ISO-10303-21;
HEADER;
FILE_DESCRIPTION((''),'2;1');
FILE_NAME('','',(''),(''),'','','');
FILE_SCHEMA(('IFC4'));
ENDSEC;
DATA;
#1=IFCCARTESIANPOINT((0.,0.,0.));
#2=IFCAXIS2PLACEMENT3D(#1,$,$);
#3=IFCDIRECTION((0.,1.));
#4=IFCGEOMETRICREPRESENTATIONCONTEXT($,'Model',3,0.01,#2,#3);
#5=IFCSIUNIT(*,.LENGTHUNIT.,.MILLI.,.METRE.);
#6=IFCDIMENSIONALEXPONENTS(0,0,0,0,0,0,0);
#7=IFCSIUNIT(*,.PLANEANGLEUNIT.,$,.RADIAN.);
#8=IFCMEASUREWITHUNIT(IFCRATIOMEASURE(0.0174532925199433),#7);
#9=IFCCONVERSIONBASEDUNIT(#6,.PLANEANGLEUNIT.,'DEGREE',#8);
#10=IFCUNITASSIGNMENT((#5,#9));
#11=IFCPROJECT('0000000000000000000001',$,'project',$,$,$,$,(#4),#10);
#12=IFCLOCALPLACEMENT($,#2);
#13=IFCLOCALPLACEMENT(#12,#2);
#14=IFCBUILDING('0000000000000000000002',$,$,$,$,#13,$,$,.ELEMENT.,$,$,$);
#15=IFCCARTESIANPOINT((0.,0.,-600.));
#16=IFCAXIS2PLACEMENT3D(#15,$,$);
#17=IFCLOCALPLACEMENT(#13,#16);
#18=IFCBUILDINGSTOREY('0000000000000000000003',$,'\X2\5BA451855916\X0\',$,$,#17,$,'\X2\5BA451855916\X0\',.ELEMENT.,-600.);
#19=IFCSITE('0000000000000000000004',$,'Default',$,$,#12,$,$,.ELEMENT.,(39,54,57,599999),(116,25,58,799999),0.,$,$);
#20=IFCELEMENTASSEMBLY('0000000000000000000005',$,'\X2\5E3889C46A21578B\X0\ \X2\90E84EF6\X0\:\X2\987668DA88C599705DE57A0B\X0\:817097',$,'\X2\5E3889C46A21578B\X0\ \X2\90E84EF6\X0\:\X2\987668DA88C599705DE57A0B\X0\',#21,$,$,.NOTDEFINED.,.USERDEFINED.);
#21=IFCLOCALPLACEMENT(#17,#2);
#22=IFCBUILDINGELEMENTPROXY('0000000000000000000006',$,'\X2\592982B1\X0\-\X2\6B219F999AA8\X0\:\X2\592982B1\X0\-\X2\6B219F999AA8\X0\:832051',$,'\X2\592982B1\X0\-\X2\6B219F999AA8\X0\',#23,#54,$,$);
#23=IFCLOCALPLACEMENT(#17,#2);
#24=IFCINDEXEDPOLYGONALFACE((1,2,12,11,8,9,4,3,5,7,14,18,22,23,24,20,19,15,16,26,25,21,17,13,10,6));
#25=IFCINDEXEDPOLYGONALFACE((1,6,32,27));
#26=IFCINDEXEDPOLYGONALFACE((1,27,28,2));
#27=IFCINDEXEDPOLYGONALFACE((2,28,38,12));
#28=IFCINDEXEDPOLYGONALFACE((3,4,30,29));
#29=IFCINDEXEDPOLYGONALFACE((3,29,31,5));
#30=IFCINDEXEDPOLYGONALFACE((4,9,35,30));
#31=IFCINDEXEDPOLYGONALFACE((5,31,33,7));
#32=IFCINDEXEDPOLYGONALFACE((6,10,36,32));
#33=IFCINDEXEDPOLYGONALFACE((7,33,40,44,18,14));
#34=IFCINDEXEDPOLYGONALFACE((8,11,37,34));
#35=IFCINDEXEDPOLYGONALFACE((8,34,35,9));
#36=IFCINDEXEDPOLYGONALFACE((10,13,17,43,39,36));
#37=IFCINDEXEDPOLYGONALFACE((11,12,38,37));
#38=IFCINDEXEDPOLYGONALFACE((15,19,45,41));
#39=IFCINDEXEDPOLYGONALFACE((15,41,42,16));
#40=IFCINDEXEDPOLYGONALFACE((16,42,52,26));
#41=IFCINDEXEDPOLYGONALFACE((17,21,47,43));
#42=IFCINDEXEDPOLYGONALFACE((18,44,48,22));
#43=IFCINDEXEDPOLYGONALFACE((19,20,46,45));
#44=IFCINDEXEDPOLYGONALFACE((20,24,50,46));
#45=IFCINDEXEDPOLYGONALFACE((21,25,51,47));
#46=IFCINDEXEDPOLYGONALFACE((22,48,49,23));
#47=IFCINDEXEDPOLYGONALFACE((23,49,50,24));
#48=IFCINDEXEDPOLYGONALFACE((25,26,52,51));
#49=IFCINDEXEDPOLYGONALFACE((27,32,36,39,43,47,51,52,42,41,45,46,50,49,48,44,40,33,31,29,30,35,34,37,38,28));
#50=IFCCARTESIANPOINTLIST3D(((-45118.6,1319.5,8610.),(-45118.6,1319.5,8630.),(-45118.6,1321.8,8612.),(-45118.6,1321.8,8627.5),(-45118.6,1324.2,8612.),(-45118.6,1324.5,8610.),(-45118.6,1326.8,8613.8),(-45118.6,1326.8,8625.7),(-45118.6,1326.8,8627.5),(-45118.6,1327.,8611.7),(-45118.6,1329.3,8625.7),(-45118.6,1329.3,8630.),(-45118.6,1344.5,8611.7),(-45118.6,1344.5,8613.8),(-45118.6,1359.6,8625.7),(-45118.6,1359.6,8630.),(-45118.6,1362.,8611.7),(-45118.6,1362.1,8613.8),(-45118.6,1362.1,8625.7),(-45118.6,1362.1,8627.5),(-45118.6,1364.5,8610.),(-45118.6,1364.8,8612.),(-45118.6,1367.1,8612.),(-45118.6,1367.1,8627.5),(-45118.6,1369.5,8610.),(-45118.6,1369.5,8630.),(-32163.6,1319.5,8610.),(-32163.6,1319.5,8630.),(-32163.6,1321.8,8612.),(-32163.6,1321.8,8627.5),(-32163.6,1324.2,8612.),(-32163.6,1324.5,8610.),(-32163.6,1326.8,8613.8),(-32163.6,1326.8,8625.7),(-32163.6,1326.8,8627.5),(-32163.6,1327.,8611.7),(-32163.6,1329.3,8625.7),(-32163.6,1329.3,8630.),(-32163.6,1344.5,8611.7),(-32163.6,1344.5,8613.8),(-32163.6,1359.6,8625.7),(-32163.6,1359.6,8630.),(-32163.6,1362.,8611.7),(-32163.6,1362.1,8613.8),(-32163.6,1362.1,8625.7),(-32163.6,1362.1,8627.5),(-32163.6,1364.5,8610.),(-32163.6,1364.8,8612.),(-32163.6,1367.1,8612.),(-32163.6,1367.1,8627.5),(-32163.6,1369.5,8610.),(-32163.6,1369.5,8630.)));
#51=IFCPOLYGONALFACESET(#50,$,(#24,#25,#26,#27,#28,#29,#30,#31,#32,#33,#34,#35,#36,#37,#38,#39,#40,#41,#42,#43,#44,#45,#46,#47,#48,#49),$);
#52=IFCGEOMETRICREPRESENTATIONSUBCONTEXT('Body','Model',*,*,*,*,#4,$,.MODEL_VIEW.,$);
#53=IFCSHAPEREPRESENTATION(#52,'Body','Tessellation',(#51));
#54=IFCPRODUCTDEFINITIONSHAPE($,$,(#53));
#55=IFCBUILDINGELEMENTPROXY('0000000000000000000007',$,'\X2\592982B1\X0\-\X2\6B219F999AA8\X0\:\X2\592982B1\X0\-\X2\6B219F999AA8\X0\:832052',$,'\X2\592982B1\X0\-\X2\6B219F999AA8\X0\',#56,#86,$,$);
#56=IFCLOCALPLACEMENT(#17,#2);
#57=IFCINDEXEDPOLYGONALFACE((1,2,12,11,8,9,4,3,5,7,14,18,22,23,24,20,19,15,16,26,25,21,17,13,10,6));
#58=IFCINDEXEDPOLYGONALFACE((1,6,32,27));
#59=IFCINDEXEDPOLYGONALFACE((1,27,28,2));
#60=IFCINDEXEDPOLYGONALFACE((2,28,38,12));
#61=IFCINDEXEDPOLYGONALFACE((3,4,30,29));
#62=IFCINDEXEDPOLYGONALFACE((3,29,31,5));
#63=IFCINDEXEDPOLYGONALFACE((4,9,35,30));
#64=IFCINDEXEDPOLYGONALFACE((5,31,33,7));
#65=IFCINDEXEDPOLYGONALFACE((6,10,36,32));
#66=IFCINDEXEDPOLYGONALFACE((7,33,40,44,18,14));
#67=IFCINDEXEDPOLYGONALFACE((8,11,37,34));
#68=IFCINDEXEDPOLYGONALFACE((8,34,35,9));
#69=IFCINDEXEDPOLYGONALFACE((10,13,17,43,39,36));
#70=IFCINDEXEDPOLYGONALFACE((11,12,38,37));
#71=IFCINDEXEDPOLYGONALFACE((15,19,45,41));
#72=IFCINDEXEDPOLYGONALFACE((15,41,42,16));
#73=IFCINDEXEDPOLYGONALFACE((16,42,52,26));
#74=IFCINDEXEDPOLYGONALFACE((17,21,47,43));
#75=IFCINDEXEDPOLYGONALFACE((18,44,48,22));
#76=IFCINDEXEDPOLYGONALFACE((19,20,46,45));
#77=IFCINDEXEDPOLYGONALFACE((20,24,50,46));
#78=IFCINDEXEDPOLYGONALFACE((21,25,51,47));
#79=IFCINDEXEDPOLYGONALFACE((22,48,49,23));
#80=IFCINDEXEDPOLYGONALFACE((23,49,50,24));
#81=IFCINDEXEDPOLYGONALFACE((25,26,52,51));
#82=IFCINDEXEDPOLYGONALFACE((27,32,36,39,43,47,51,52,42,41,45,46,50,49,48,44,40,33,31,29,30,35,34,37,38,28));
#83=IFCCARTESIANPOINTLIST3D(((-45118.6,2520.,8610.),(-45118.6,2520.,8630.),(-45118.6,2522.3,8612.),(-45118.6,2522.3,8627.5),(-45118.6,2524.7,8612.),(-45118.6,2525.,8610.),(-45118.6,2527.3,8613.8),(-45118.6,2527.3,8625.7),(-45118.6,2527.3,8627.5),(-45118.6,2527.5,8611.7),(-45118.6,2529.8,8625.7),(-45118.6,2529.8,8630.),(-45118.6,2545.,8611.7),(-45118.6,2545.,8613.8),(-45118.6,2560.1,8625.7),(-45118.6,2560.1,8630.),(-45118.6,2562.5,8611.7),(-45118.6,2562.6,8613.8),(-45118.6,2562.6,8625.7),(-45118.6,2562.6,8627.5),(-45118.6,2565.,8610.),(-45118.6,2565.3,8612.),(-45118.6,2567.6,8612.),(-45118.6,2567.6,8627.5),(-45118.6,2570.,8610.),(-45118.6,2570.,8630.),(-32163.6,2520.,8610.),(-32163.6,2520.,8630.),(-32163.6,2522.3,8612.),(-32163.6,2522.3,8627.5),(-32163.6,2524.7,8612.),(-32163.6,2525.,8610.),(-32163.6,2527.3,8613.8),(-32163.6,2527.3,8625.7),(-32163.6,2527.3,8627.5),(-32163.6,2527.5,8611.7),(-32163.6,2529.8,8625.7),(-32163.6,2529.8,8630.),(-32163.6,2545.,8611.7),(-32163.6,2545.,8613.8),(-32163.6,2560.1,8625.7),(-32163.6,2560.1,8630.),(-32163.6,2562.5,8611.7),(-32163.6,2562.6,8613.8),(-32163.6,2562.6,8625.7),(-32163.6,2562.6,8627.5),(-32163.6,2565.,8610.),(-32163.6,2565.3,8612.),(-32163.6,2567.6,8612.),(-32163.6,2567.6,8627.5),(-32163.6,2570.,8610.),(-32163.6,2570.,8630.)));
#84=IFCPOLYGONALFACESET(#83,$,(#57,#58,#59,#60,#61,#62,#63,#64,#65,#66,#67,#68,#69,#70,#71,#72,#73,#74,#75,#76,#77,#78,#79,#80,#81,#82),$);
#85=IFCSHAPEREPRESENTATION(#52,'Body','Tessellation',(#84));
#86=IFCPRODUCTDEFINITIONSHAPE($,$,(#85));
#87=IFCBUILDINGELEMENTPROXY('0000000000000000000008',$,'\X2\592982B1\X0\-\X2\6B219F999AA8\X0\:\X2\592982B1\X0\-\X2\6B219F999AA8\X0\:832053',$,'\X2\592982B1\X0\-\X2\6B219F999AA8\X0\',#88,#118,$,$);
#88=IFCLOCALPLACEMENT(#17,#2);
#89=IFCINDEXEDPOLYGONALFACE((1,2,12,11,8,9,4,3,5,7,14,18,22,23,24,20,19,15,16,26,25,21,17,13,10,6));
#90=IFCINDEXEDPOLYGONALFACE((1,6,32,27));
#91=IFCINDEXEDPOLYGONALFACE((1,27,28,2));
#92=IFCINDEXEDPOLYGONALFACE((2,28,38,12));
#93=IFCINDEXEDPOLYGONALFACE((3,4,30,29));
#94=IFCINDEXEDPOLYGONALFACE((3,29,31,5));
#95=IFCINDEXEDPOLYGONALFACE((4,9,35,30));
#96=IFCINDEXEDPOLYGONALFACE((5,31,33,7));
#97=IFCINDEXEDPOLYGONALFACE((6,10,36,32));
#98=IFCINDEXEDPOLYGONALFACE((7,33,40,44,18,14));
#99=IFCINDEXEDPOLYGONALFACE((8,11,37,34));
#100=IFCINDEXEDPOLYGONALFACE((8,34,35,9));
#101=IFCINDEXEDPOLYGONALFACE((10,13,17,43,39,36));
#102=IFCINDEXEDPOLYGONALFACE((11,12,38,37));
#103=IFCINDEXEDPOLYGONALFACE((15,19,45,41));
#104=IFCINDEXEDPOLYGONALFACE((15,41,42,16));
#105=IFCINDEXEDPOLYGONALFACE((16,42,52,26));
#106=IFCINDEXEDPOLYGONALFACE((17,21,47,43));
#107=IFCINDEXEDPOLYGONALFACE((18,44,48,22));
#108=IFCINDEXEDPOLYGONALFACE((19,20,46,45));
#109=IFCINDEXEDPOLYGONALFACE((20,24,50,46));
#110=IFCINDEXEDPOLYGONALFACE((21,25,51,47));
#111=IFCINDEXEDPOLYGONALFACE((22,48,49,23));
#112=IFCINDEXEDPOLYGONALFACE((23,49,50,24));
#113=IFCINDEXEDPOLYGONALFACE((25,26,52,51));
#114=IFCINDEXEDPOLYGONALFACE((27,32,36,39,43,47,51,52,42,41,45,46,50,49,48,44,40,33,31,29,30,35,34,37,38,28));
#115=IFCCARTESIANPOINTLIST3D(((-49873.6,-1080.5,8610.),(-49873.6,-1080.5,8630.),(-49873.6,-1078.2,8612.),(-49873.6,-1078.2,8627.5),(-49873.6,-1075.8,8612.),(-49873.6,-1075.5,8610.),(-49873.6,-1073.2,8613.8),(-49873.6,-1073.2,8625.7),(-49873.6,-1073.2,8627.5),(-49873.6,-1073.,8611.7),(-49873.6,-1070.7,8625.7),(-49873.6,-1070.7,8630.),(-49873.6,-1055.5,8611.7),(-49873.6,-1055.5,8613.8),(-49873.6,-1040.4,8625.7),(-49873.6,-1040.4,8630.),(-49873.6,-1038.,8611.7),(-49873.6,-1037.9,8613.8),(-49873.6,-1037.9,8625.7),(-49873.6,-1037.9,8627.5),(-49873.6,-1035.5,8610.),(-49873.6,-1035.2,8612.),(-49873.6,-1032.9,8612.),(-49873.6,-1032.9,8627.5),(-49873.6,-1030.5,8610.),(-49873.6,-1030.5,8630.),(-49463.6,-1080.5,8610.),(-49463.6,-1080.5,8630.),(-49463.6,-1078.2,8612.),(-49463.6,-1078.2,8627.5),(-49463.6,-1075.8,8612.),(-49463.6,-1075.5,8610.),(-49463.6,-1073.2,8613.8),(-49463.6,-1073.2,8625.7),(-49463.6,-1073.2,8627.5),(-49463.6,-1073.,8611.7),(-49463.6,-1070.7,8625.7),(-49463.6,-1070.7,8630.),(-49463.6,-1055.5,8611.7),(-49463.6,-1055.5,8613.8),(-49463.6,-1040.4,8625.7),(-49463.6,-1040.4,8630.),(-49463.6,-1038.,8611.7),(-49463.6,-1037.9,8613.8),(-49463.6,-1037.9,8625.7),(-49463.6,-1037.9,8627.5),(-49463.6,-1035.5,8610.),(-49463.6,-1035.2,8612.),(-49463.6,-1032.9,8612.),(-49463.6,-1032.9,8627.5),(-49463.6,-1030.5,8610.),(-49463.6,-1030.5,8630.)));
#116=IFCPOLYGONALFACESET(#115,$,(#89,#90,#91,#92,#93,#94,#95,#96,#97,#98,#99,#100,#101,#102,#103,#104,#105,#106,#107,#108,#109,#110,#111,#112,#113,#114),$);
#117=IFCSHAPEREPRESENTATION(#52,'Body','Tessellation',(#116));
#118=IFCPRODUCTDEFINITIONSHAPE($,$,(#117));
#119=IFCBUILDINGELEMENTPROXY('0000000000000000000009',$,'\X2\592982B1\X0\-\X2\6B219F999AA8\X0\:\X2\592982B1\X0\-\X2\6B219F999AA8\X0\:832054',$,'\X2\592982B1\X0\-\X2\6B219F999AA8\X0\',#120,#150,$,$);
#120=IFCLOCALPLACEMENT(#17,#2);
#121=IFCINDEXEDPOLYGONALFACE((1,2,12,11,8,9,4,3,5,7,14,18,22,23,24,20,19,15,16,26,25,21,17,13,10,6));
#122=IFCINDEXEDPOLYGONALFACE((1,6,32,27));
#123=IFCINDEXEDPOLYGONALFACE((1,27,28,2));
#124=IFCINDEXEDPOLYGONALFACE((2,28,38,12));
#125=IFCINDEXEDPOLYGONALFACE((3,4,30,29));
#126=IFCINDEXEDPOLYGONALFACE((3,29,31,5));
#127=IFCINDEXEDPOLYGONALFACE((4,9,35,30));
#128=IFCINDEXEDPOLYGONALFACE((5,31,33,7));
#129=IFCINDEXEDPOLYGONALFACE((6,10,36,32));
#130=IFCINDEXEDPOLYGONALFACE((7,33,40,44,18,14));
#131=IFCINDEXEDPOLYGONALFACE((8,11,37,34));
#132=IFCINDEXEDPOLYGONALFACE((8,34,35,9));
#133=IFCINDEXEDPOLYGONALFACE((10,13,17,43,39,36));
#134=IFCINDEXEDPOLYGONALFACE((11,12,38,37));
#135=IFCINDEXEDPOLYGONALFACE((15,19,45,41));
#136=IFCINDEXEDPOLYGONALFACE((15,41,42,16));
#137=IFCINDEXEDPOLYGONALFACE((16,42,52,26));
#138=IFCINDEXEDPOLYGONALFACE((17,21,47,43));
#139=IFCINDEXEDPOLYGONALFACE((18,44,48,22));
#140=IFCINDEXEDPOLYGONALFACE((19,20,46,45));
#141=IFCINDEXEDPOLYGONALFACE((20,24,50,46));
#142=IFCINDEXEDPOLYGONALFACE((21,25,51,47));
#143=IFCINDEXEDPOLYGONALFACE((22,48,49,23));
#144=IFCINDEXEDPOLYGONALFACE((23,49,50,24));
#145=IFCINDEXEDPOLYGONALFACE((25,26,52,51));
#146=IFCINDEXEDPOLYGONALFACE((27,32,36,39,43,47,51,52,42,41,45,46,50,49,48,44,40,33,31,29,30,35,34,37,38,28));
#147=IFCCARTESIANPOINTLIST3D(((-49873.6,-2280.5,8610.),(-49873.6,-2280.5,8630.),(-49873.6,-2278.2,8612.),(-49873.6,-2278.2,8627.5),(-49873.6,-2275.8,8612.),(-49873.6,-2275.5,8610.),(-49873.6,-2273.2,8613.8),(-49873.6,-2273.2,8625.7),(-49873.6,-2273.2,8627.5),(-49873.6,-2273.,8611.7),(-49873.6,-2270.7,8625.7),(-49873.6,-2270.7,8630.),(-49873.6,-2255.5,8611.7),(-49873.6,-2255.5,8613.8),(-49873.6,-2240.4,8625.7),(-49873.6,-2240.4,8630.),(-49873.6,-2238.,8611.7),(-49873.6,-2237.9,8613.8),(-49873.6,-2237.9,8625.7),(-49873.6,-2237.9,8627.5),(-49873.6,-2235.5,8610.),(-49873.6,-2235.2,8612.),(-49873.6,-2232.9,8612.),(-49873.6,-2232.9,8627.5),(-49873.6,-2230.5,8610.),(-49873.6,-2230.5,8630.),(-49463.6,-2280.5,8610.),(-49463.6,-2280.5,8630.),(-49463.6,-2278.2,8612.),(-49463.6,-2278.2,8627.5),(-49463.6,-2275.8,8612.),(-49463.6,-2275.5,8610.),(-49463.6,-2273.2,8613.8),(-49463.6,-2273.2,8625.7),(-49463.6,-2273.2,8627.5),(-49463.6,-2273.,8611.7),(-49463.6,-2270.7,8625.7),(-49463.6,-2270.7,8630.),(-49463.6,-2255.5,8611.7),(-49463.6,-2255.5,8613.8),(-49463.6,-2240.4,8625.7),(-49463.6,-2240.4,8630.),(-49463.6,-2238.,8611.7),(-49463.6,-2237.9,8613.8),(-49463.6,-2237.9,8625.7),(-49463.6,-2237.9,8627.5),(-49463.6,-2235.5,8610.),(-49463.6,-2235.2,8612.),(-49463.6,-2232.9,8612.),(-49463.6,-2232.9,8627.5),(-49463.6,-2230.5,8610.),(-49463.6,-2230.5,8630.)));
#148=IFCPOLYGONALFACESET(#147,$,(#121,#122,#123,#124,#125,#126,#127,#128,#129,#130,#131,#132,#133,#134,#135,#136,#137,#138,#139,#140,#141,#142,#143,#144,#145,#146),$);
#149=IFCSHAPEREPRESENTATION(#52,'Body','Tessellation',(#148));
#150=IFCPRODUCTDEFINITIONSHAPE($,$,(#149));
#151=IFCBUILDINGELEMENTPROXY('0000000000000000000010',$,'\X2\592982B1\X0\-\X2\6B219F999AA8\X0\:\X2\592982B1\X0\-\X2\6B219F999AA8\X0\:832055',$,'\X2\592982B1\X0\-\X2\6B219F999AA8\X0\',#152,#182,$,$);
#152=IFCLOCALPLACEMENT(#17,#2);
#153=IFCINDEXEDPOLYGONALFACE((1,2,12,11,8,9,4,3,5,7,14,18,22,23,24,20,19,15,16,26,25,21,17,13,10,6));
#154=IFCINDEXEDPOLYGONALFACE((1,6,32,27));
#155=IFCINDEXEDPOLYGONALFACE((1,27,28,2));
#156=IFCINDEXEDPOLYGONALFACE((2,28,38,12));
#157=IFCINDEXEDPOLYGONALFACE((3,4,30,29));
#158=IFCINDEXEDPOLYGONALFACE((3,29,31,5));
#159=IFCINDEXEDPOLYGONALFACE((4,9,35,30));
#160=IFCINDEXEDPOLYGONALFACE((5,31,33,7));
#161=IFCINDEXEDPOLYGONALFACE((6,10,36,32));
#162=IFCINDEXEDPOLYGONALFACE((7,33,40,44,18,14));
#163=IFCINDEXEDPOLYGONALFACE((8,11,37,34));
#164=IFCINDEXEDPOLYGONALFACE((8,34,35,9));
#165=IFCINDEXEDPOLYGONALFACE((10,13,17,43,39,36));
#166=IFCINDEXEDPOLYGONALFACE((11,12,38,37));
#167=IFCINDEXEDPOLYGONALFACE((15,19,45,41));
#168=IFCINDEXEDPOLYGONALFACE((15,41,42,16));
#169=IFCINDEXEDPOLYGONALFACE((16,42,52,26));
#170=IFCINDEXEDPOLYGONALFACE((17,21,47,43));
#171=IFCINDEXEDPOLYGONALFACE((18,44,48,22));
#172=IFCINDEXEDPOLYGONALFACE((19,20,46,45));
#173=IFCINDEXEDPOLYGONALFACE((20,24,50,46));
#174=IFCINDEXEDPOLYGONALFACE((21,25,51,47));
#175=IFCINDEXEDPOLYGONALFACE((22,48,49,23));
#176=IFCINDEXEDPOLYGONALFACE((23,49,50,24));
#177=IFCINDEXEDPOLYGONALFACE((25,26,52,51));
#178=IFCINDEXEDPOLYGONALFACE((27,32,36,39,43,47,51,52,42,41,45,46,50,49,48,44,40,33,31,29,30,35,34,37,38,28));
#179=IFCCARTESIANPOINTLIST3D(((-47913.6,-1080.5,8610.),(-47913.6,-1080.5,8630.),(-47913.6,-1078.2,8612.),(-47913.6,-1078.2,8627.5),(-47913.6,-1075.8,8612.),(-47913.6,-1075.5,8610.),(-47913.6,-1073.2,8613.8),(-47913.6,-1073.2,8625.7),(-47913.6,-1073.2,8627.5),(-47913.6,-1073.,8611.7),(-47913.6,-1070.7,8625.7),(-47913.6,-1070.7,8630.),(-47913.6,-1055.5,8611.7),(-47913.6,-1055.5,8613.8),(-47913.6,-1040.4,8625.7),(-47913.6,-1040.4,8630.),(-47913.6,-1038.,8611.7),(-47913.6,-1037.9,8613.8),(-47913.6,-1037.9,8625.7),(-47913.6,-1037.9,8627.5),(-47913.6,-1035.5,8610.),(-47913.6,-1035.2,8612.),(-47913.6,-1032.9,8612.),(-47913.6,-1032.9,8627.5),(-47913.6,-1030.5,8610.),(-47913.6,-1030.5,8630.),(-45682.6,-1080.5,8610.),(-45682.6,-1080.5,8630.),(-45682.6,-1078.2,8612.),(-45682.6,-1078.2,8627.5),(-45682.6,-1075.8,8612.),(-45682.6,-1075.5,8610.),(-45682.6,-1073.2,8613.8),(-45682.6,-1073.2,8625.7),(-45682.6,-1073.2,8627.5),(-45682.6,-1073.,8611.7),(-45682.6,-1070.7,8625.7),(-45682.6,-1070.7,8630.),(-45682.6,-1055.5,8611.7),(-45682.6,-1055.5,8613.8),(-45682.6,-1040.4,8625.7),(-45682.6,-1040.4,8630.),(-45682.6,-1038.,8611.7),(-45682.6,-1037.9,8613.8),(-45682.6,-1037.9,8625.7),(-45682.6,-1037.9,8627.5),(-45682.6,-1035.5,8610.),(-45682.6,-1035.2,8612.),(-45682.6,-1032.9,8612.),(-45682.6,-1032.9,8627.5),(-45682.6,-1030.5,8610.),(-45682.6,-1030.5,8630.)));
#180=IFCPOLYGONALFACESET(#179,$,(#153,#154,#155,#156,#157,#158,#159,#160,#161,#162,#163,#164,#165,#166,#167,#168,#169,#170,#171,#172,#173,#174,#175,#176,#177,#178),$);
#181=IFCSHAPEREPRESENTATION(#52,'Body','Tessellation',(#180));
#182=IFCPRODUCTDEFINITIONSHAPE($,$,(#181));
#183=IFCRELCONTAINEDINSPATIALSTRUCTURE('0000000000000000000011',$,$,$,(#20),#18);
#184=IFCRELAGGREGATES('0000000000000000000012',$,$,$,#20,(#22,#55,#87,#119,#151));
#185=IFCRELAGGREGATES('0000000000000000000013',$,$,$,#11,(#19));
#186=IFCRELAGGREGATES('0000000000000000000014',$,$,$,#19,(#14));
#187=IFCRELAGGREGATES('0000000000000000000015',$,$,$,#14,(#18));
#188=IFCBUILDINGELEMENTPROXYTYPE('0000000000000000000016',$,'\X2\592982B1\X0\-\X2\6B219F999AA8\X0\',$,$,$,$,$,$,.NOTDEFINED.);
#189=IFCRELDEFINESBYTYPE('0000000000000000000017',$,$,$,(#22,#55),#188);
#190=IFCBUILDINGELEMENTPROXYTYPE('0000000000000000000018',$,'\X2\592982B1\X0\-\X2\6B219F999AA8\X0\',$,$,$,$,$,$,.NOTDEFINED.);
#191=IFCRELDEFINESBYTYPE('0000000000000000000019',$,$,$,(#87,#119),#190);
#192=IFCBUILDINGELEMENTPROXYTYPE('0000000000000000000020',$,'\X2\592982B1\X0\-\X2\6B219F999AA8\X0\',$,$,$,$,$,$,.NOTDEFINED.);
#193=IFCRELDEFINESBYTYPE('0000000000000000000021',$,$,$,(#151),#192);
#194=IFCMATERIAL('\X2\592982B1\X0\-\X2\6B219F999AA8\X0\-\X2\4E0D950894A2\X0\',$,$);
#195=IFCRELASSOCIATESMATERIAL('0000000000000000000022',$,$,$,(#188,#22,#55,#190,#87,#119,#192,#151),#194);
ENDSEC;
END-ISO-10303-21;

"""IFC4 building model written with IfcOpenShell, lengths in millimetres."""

from ifc_helpers import new_model, entity, si_unit, converted_unit, direction, frame, origin, place, context, subcontext, project, spatial, polyline, outline, extrude, source, transform, mapped, material, type_object, type_shapes, element, aggregate, save


model = new_model("IFC4")

# Units and contexts
model_context = context("Model", 3, precision=0.01, world=origin(), true_north=direction((0.0, 1.0)))
body_context = subcontext(model_context, "Body", "Model", "MODEL_VIEW")
ifc_project = project(units=[si_unit("LENGTHUNIT", "METRE", prefix="MILLI"), converted_unit("PLANEANGLEUNIT", "DEGREE", entity("IfcRatioMeasure", 0.0174532925199433), si_unit("PLANEANGLEUNIT", "RADIAN"), dimensions=[0, 0, 0, 0, 0, 0, 0])], contexts=[model_context])

# Site, building, storey
site_placement = place(None, origin())
site = spatial("IfcSite", under=ifc_project, at=site_placement, Name="Default", CompositionType="ELEMENT", RefLatitude=(39, 54, 57, 599999), RefLongitude=(116, 25, 58, 799999), RefElevation=0.0)
building_placement = place(site_placement, origin())
building = spatial("IfcBuilding", under=site, at=building_placement, CompositionType="ELEMENT")
storey_placement = place(building_placement, frame((0.0, 0.0, -600.0)))
storey = spatial("IfcBuildingStorey", under=building, at=storey_placement, Name="室内外", LongName="室内外", CompositionType="ELEMENT", Elevation=-600.0)

# Element assembly, building element proxies
assembly_1_placement = place(storey_placement, origin())
assembly_1 = element("IfcElementAssembly", 1, at=assembly_1_placement, inside=storey, Name="常规模型 部件:顶棚装饰工程:817097", ObjectType="常规模型 部件:顶棚装饰工程", AssemblyPlace="NOTDEFINED", PredefinedType="USERDEFINED")
ifc_material_1 = material(Name="天花-次龙骨-不锈钢")
building_element_proxy_type_1 = type_object("IfcBuildingElementProxyType", Name="天花-次龙骨", PredefinedType="NOTDEFINED", material=ifc_material_1)
shared_shape_1 = source(origin(), body_context, "Body", "SweptSolid", [
    extrude(outline(polyline([(-25.0, -9.1), (-20.0, -9.1), (-17.5, -7.4), (0.0, -7.4), (17.5, -7.4), (20.0, -9.1), (25.0, -9.1), (25.0, 10.9), (15.1, 10.9), (15.1, 6.6), (17.6, 6.6), (17.6, 8.4), (22.6, 8.4), (22.6, -7.1), (20.3, -7.1), (17.6, -5.3), (0.0, -5.3), (-17.6, -5.3), (-20.3, -7.1), (-22.6, -7.1), (-22.6, 8.4), (-17.6, 8.4), (-17.6, 6.6), (-15.1, 6.6), (-15.1, 10.9), (-25.0, 10.9), (-25.0, -9.1)])), frame((0.0, 0.0, -0.9), z_axis=(1.0, 0.0, 0.0), x_axis=(0.0, 1.0, 0.0)), (0.0, 0.0, 1.0), 12955.0),
])
type_shapes(building_element_proxy_type_1, [shared_shape_1])
proxy_1_placement = place(assembly_1_placement, frame((-45118.6, 1344.5, 8620.0)))
proxy_1 = element("IfcBuildingElementProxy", 2, at=proxy_1_placement, type_object=building_element_proxy_type_1, material=ifc_material_1, Name="天花-次龙骨:天花-次龙骨:832051", ObjectType="天花-次龙骨", context=body_context, shape_type="MappedRepresentation", body=[
    mapped(shared_shape_1, transform((0.0, 0.0, 0.0), scale=1.0)),
])
proxy_2_placement = place(assembly_1_placement, frame((-45118.6, 2545.0, 8620.0)))
proxy_2 = element("IfcBuildingElementProxy", 3, at=proxy_2_placement, type_object=building_element_proxy_type_1, material=ifc_material_1, Name="天花-次龙骨:天花-次龙骨:832052", ObjectType="天花-次龙骨", context=body_context, shape_type="MappedRepresentation", body=[
    mapped(shared_shape_1, transform((0.0, 0.0, 0.0), scale=1.0)),
])
building_element_proxy_type_2 = type_object("IfcBuildingElementProxyType", Name="天花-次龙骨", PredefinedType="NOTDEFINED", material=ifc_material_1)
shared_shape_2 = source(origin(), body_context, "Body", "SweptSolid", [
    extrude(outline(polyline([(-25.0, -9.1), (-20.0, -9.1), (-17.5, -7.4), (0.0, -7.4), (17.5, -7.4), (20.0, -9.1), (25.0, -9.1), (25.0, 10.9), (15.1, 10.9), (15.1, 6.6), (17.6, 6.6), (17.6, 8.4), (22.6, 8.4), (22.6, -7.1), (20.3, -7.1), (17.6, -5.3), (0.0, -5.3), (-17.6, -5.3), (-20.3, -7.1), (-22.6, -7.1), (-22.6, 8.4), (-17.6, 8.4), (-17.6, 6.6), (-15.1, 6.6), (-15.1, 10.9), (-25.0, 10.9), (-25.0, -9.1)])), frame((0.0, 0.0, -0.9), z_axis=(1.0, 0.0, 0.0), x_axis=(0.0, 1.0, 0.0)), (0.0, 0.0, 1.0), 410.0),
])
type_shapes(building_element_proxy_type_2, [shared_shape_2])
proxy_3_placement = place(assembly_1_placement, frame((-49873.6, -1055.5, 8620.0)))
proxy_3 = element("IfcBuildingElementProxy", 4, at=proxy_3_placement, type_object=building_element_proxy_type_2, material=ifc_material_1, Name="天花-次龙骨:天花-次龙骨:832053", ObjectType="天花-次龙骨", context=body_context, shape_type="MappedRepresentation", body=[
    mapped(shared_shape_2, transform((0.0, 0.0, 0.0), scale=1.0)),
])
proxy_4_placement = place(assembly_1_placement, frame((-49873.6, -2255.5, 8620.0)))
proxy_4 = element("IfcBuildingElementProxy", 5, at=proxy_4_placement, type_object=building_element_proxy_type_2, material=ifc_material_1, Name="天花-次龙骨:天花-次龙骨:832054", ObjectType="天花-次龙骨", context=body_context, shape_type="MappedRepresentation", body=[
    mapped(shared_shape_2, transform((0.0, 0.0, 0.0), scale=1.0)),
])
building_element_proxy_type_3 = type_object("IfcBuildingElementProxyType", Name="天花-次龙骨", PredefinedType="NOTDEFINED", material=ifc_material_1)
shared_shape_3 = source(origin(), body_context, "Body", "SweptSolid", [
    extrude(outline(polyline([(-25.0, -9.1), (-20.0, -9.1), (-17.5, -7.4), (0.0, -7.4), (17.5, -7.4), (20.0, -9.1), (25.0, -9.1), (25.0, 10.9), (15.1, 10.9), (15.1, 6.6), (17.6, 6.6), (17.6, 8.4), (22.6, 8.4), (22.6, -7.1), (20.3, -7.1), (17.6, -5.3), (0.0, -5.3), (-17.6, -5.3), (-20.3, -7.1), (-22.6, -7.1), (-22.6, 8.4), (-17.6, 8.4), (-17.6, 6.6), (-15.1, 6.6), (-15.1, 10.9), (-25.0, 10.9), (-25.0, -9.1)])), frame((0.0, 0.0, -0.9), z_axis=(1.0, 0.0, 0.0), x_axis=(0.0, 1.0, 0.0)), (0.0, 0.0, 1.0), 2231.0),
])
type_shapes(building_element_proxy_type_3, [shared_shape_3])
proxy_5_placement = place(assembly_1_placement, frame((-47913.6, -1055.5, 8620.0)))
proxy_5 = element("IfcBuildingElementProxy", 6, at=proxy_5_placement, type_object=building_element_proxy_type_3, material=ifc_material_1, Name="天花-次龙骨:天花-次龙骨:832055", ObjectType="天花-次龙骨", context=body_context, shape_type="MappedRepresentation", body=[
    mapped(shared_shape_3, transform((0.0, 0.0, 0.0), scale=1.0)),
])
aggregate(assembly_1, [proxy_1, proxy_2, proxy_3, proxy_4, proxy_5])

save(model, "model.ifc")
